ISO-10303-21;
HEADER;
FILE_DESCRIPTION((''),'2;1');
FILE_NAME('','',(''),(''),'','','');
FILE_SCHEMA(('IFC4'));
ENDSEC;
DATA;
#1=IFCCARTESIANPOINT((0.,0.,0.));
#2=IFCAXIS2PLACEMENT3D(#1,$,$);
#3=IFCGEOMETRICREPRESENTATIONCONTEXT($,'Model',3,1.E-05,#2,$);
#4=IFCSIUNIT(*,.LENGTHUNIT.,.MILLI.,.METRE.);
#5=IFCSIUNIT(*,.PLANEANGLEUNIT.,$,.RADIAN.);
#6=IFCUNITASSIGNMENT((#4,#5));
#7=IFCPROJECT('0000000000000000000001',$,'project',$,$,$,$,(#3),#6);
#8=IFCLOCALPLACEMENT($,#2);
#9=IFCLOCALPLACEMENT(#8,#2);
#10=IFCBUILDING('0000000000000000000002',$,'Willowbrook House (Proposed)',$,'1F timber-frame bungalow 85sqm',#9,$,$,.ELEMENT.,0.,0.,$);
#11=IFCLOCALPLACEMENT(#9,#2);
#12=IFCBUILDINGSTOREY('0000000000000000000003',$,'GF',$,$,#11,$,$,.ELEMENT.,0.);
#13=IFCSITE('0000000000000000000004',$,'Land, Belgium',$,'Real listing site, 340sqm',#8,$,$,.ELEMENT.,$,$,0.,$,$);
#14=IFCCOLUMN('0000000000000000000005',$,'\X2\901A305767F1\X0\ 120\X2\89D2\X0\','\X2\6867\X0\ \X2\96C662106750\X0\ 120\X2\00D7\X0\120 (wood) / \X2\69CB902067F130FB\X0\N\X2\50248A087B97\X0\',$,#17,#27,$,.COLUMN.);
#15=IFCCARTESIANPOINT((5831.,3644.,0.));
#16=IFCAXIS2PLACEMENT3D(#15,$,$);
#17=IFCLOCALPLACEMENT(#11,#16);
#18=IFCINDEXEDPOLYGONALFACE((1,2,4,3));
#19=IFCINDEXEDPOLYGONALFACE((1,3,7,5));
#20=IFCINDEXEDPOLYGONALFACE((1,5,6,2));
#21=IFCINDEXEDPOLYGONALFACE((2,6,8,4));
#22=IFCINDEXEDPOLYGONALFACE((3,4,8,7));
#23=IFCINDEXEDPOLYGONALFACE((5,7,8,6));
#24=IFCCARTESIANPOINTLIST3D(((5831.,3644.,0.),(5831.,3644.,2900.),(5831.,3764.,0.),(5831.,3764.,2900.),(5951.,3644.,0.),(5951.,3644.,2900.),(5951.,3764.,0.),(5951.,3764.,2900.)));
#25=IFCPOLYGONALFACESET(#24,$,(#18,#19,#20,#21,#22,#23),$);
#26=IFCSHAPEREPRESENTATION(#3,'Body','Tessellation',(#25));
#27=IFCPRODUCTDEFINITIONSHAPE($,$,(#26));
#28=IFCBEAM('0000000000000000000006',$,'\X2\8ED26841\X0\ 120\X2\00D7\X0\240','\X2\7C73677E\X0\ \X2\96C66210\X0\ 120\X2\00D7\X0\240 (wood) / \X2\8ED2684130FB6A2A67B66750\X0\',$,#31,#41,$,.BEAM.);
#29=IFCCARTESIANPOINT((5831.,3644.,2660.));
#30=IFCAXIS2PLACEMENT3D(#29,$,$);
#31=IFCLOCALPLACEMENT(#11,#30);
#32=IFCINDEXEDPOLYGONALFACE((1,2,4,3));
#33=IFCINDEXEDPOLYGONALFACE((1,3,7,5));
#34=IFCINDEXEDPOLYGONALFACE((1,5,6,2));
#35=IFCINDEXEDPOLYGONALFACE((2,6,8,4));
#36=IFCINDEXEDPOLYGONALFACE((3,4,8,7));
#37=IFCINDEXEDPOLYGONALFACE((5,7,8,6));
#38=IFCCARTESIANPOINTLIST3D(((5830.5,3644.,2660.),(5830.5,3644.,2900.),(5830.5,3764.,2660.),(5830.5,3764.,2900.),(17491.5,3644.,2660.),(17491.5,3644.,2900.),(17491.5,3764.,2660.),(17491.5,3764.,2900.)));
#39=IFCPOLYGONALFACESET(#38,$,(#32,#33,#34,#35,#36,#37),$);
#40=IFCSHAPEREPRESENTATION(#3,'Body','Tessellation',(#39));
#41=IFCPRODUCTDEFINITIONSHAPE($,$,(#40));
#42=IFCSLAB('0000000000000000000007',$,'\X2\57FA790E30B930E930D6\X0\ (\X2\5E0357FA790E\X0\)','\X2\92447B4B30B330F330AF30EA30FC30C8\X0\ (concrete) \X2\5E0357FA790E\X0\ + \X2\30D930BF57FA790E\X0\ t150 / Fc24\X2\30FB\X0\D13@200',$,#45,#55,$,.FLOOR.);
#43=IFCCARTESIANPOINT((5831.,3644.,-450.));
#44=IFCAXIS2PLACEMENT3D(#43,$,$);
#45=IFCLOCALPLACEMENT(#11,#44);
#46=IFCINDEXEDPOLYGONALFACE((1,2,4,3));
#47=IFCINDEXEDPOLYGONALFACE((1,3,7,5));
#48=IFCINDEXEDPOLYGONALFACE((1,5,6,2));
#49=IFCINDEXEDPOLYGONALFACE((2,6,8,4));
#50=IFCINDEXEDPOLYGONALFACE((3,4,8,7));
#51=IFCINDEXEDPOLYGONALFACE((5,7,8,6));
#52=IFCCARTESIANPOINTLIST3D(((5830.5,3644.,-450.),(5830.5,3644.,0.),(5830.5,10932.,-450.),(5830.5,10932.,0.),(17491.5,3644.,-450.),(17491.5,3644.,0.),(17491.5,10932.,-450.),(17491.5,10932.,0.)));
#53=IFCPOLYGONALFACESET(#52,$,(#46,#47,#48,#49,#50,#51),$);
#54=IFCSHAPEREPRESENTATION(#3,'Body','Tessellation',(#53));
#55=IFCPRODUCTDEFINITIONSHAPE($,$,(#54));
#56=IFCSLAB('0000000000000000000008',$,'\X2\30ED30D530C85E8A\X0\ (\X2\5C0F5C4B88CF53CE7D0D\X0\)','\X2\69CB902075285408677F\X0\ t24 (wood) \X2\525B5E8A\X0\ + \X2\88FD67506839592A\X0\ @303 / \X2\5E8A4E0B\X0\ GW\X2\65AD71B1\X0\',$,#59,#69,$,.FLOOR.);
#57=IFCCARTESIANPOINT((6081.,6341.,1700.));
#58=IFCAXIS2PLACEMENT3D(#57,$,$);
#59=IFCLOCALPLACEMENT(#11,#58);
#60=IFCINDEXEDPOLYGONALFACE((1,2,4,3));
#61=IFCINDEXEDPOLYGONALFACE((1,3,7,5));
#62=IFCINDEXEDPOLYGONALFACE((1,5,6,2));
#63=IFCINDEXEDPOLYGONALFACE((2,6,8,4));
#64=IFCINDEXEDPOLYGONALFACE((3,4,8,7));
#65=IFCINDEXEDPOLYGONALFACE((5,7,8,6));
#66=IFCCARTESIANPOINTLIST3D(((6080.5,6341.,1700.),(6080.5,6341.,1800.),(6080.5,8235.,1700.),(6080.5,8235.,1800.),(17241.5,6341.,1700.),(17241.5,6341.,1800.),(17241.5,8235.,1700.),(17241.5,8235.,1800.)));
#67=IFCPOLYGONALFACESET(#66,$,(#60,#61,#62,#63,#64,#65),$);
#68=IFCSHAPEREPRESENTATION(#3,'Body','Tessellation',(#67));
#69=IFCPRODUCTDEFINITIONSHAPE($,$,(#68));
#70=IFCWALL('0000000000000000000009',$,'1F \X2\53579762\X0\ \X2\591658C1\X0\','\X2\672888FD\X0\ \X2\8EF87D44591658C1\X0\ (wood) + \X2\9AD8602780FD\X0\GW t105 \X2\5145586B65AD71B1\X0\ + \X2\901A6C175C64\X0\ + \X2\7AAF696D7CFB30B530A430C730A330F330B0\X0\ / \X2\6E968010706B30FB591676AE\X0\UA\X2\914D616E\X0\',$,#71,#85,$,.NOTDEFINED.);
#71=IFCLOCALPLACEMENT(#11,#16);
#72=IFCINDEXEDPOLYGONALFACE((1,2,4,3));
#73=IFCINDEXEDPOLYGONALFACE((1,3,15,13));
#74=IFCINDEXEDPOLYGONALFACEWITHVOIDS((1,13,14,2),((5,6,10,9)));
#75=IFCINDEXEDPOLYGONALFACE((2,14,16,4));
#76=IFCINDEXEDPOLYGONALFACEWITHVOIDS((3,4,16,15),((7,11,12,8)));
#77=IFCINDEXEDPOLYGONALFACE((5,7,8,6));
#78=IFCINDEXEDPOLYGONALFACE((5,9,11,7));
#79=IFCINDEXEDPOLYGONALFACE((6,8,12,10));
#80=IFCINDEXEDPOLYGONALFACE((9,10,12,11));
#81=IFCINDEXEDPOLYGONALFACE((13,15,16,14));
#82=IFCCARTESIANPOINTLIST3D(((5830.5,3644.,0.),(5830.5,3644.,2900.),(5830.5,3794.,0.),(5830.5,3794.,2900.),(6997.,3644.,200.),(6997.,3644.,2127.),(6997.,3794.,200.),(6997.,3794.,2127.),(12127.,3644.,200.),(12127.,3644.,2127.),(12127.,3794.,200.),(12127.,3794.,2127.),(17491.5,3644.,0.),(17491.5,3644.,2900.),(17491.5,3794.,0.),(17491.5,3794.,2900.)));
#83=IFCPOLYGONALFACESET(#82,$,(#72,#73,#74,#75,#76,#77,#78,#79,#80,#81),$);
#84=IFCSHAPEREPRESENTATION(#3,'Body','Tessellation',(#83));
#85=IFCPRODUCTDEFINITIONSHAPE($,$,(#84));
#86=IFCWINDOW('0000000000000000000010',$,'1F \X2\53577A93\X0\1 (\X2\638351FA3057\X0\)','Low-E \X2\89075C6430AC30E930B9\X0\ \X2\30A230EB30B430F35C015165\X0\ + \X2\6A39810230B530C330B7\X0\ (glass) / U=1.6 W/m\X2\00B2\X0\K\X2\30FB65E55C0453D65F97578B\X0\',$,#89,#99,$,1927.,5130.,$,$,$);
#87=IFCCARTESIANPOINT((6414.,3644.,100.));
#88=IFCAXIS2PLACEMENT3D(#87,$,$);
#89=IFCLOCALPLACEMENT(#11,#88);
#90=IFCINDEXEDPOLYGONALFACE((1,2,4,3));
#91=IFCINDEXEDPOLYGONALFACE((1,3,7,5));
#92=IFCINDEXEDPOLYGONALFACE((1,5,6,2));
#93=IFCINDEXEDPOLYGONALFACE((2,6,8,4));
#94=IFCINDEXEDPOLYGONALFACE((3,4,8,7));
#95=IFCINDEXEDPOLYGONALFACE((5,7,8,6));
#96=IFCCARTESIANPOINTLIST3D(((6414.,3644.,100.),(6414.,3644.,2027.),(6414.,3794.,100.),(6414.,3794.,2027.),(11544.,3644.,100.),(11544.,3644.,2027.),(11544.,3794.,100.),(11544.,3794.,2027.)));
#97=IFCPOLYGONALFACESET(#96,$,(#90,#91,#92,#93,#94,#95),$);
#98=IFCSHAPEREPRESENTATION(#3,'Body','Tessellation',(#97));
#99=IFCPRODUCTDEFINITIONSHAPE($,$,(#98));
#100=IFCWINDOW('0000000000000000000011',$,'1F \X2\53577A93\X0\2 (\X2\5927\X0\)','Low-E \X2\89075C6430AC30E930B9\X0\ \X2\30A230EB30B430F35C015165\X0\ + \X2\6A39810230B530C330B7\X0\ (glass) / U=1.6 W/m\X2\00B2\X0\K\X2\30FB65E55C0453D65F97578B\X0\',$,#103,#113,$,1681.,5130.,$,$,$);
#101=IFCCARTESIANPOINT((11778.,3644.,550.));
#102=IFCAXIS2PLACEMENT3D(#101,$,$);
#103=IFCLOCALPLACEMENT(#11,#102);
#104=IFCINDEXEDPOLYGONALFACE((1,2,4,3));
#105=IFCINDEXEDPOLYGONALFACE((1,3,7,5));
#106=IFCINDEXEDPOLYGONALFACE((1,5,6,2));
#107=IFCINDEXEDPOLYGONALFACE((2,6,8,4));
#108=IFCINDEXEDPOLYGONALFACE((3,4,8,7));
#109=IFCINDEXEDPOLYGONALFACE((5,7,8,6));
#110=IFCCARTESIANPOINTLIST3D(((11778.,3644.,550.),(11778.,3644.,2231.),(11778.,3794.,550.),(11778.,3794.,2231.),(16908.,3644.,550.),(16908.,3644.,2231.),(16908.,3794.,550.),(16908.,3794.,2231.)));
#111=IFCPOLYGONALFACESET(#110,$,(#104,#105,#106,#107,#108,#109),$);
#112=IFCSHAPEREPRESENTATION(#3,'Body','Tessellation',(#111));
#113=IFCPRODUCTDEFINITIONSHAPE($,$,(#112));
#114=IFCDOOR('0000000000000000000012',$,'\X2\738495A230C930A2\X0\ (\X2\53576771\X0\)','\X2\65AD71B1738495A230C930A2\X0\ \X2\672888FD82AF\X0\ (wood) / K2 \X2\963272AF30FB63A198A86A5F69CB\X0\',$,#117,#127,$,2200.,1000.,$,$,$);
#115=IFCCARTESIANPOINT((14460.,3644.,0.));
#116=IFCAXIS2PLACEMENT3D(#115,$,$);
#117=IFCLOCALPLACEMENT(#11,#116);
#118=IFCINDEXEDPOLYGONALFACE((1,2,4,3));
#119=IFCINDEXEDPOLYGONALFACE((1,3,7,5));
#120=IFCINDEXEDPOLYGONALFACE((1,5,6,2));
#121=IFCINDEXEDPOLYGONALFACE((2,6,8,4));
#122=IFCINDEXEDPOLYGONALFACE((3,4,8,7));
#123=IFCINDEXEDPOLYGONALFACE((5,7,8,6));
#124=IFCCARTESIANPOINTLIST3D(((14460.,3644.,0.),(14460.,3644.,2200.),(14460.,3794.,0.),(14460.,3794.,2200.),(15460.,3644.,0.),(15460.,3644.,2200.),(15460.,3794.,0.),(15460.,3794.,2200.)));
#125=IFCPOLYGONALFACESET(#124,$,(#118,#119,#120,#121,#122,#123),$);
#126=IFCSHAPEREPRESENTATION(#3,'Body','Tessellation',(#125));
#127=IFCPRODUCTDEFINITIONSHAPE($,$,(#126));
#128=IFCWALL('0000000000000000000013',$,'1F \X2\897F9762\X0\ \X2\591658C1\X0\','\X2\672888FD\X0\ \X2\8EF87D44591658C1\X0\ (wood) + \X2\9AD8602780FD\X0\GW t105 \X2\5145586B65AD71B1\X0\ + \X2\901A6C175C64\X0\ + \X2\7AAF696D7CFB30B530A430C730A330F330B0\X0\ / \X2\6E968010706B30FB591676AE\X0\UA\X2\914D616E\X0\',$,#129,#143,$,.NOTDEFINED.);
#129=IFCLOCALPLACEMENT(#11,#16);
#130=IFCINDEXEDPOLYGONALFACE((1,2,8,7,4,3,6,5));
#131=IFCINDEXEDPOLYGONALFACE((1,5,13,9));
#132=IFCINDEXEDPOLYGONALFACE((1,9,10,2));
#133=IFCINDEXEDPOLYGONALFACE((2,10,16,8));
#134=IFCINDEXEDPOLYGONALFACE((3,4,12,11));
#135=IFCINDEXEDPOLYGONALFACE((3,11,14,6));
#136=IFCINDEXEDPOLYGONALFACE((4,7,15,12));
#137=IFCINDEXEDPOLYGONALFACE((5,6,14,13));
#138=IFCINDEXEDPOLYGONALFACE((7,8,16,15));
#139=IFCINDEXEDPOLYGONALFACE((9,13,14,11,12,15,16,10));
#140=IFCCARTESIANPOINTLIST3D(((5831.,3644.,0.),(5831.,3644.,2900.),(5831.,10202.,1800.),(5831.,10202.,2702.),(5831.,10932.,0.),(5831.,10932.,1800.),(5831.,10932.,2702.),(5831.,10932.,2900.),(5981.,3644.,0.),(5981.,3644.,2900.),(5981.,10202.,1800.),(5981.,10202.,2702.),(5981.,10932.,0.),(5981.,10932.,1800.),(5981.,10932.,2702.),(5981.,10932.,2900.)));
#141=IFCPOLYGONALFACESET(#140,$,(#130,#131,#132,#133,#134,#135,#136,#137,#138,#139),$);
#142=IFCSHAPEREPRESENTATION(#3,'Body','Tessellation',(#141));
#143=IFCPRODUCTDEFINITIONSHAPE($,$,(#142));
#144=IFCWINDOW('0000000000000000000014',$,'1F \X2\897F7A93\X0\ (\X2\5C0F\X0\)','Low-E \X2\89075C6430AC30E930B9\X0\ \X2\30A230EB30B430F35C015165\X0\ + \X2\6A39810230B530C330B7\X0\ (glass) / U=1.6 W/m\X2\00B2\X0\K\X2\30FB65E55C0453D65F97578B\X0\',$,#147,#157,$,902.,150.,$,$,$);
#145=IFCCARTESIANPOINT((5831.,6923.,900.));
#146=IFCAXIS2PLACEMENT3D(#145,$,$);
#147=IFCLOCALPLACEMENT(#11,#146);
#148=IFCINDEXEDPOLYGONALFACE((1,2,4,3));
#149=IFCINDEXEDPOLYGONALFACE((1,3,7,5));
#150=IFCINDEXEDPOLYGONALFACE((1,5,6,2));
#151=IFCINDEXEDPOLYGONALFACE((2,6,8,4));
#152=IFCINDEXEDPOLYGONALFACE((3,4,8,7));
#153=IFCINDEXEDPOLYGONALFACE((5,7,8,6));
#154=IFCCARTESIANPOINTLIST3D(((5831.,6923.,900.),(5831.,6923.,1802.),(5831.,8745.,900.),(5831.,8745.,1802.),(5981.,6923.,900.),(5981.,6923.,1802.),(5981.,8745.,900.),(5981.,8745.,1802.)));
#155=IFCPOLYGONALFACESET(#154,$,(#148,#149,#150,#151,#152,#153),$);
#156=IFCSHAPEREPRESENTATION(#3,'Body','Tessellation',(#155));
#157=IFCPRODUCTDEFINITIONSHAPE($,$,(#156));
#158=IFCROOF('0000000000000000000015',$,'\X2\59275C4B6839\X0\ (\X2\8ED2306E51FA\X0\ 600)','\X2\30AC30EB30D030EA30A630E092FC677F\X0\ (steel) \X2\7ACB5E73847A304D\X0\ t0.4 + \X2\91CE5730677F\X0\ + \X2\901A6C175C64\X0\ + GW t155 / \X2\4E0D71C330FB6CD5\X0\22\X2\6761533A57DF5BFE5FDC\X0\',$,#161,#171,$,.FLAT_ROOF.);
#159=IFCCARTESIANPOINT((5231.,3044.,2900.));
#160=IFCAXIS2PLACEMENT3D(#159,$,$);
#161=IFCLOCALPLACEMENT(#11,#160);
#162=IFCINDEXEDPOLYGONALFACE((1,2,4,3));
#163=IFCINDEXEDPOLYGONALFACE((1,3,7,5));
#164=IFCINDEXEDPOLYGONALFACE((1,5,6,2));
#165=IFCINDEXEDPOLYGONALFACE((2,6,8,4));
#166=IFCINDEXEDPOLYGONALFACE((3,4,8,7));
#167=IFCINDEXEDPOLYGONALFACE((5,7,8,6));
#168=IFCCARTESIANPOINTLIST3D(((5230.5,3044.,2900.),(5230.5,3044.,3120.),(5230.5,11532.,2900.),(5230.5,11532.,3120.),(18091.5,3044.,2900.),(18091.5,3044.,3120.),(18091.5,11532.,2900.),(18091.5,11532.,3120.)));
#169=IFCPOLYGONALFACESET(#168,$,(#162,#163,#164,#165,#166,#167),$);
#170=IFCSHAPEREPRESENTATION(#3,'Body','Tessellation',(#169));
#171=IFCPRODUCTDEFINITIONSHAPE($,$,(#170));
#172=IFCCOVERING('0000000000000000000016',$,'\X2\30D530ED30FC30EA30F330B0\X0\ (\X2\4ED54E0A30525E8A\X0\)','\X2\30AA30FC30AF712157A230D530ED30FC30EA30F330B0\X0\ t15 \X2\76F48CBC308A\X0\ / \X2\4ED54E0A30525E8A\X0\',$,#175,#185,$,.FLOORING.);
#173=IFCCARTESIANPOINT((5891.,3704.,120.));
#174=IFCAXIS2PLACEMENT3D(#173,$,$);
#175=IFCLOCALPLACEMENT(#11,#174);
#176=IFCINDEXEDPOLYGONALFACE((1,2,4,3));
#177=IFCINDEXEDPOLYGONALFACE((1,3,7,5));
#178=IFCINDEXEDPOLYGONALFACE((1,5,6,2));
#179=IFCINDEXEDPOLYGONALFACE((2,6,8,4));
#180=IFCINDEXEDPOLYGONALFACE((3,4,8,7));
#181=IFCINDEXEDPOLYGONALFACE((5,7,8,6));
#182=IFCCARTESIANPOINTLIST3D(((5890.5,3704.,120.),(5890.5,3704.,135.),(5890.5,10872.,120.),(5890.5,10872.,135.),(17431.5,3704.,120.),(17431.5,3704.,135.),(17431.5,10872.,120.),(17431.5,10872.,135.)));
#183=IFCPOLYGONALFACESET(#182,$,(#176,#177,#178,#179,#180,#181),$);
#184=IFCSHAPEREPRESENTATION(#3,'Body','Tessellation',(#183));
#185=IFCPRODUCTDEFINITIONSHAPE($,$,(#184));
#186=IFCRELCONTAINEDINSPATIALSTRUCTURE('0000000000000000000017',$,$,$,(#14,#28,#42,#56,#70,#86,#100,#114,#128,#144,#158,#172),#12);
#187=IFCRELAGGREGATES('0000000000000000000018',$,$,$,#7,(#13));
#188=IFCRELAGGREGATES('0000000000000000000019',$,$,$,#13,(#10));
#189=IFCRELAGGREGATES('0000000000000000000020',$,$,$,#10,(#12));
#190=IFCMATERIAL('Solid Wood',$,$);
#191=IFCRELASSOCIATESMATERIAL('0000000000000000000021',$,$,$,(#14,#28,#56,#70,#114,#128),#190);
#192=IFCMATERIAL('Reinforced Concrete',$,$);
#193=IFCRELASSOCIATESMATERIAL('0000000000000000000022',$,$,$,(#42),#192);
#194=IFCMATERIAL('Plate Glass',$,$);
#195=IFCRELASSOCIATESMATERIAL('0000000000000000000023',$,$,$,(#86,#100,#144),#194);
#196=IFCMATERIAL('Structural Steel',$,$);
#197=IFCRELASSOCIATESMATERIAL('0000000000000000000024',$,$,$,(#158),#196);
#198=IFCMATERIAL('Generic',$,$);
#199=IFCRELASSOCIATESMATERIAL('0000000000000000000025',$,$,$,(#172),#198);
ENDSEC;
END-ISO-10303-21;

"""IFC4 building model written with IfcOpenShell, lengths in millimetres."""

from ifc_helpers import new_model, si_unit, frame, frame_2d, origin, place, context, project, spatial, rectangle, extrude, material, element, fill, save


model = new_model("IFC4")

# Units and contexts
model_context = context("Model", 3, precision=1e-05, world=origin())
ifc_project = project(units=[si_unit("LENGTHUNIT", "METRE", prefix="MILLI"), si_unit("PLANEANGLEUNIT", "RADIAN")], contexts=[model_context])

# Site, building, storey
site_placement = place(None, origin())
site = spatial("IfcSite", under=ifc_project, at=site_placement, Name="Land, Belgium", ObjectType="Real listing site, 340sqm", CompositionType="ELEMENT", RefElevation=0.0)
building_placement = place(site_placement, origin())
building = spatial("IfcBuilding", under=site, at=building_placement, Name="Willowbrook House (Proposed)", ObjectType="1F timber-frame bungalow 85sqm", CompositionType="ELEMENT", ElevationOfRefHeight=0.0, ElevationOfTerrain=0.0)
storey_placement = place(building_placement, origin())
storey = spatial("IfcBuildingStorey", under=building, at=storey_placement, Name="GF", CompositionType="ELEMENT", Elevation=0.0)

# Column
ifc_material_1 = material(Name="Solid Wood")
column_1_placement = place(storey_placement, frame((5831.0, 3644.0, 0.0)))
element("IfcColumn", 1, at=column_1_placement, inside=storey, material=ifc_material_1, Name="通し柱 120角", Description="桧 集成材 120×120 (wood) / 構造柱・N値計算", PredefinedType="COLUMN", context=model_context, shape_type="SweptSolid", body=[
    extrude(rectangle(XDim=120.0, YDim=120.0, at=frame_2d((60.0, 60.0))), frame((5831.0, 3644.0, 0.0)), (0.0, 0.0, 1.0), 2900.0),
])

# Beam
beam_1_placement = place(storey_placement, frame((5831.0, 3644.0, 2660.0)))
element("IfcBeam", 2, at=beam_1_placement, inside=storey, material=ifc_material_1, Name="軒桁 120×240", Description="米松 集成 120×240 (wood) / 軒桁・横架材", PredefinedType="BEAM", context=model_context, shape_type="SweptSolid", body=[
    extrude(rectangle(XDim=11661.0, YDim=120.0, at=frame_2d((5830.0, 60.0))), frame((5831.0, 3644.0, 2660.0)), (0.0, 0.0, 1.0), 240.0),
])

# Slabs
ifc_material_2 = material(Name="Reinforced Concrete")
slab_1_placement = place(storey_placement, frame((5831.0, 3644.0, -450.0)))
element("IfcSlab", 3, at=slab_1_placement, inside=storey, material=ifc_material_2, Name="基礎スラブ (布基礎)", Description="鉄筋コンクリート (concrete) 布基礎 + ベタ基礎 t150 / Fc24・D13@200", PredefinedType="FLOOR", context=model_context, shape_type="SweptSolid", body=[
    extrude(rectangle(XDim=11661.0, YDim=7288.0, at=frame_2d((5830.0, 3644.0))), frame((5831.0, 3644.0, -450.0)), (0.0, 0.0, 1.0), 450.0),
])
slab_2_placement = place(storey_placement, frame((6081.0, 6341.0, 1700.0)))
element("IfcSlab", 4, at=slab_2_placement, inside=storey, material=ifc_material_1, Name="ロフト床 (小屋裏収納)", Description="構造用合板 t24 (wood) 剛床 + 製材根太 @303 / 床下 GW断熱", PredefinedType="FLOOR", context=model_context, shape_type="SweptSolid", body=[
    extrude(rectangle(XDim=11161.0, YDim=1894.0, at=frame_2d((5580.0, 947.0))), frame((6081.0, 6341.0, 1700.0)), (0.0, 0.0, 1.0), 100.0),
])

# Wall, openings, windows, door
wall_1_placement = place(storey_placement, frame((5831.0, 3644.0, 0.0)))
wall_1 = element("IfcWall", 5, at=wall_1_placement, inside=storey, material=ifc_material_1, Name="1F 南面 外壁", Description="木製 軸組外壁 (wood) + 高性能GW t105 充填断熱 + 通気層 + 窯業系サイディング / 準耐火・外皮UA配慮", PredefinedType="NOTDEFINED", context=model_context, shape_type="SweptSolid", body=[
    extrude(rectangle(XDim=11661.0, YDim=150.0, at=frame_2d((5830.0, 75.0))), frame((5831.0, 3644.0, 0.0)), (0.0, 0.0, 1.0), 2900.0),
])
opening_1_placement = place(storey_placement, frame((6414.0, 3644.0, 100.0)))
opening_1 = element("IfcOpeningElement", 6, at=opening_1_placement, cuts=wall_1, PredefinedType="NOTDEFINED", context=model_context, shape_type="SweptSolid", body=[
    extrude(rectangle(XDim=5130.0, YDim=150.0, at=frame_2d((2565.0, 75.0))), frame((6414.0, 3644.0, 100.0)), (0.0, 0.0, 1.0), 1927.0),
])
opening_2_placement = place(storey_placement, frame((11778.0, 3644.0, 550.0)))
opening_2 = element("IfcOpeningElement", 7, at=opening_2_placement, cuts=wall_1, PredefinedType="NOTDEFINED", context=model_context, shape_type="SweptSolid", body=[
    extrude(rectangle(XDim=5130.0, YDim=150.0, at=frame_2d((2565.0, 75.0))), frame((11778.0, 3644.0, 550.0)), (0.0, 0.0, 1.0), 1681.0),
])
opening_3_placement = place(storey_placement, frame((14460.0, 3644.0, 0.0)))
opening_3 = element("IfcOpeningElement", 8, at=opening_3_placement, cuts=wall_1, PredefinedType="NOTDEFINED", context=model_context, shape_type="SweptSolid", body=[
    extrude(rectangle(XDim=1000.0, YDim=150.0, at=frame_2d((500.0, 75.0))), frame((14460.0, 3644.0, 0.0)), (0.0, 0.0, 1.0), 2200.0),
])
ifc_material_3 = material(Name="Plate Glass")
window_1_placement = place(storey_placement, frame((6414.0, 3644.0, 100.0)))
window_1 = element("IfcWindow", 9, at=window_1_placement, inside=storey, material=ifc_material_3, Name="1F 南窓1 (掃出し)", Description="Low-E 複層ガラス アルゴン封入 + 樹脂サッシ (glass) / U=1.6 W/m²K・日射取得型", OverallHeight=1927.0, OverallWidth=5130.0, context=model_context, shape_type="SweptSolid", body=[
    extrude(rectangle(XDim=5130.0, YDim=150.0, at=frame_2d((2565.0, 75.0))), frame((6414.0, 3644.0, 100.0)), (0.0, 0.0, 1.0), 1927.0),
])
fill(opening_1, window_1)
window_2_placement = place(storey_placement, frame((11778.0, 3644.0, 550.0)))
window_2 = element("IfcWindow", 10, at=window_2_placement, inside=storey, material=ifc_material_3, Name="1F 南窓2 (大)", Description="Low-E 複層ガラス アルゴン封入 + 樹脂サッシ (glass) / U=1.6 W/m²K・日射取得型", OverallHeight=1681.0, OverallWidth=5130.0, context=model_context, shape_type="SweptSolid", body=[
    extrude(rectangle(XDim=5130.0, YDim=150.0, at=frame_2d((2565.0, 75.0))), frame((11778.0, 3644.0, 550.0)), (0.0, 0.0, 1.0), 1681.0),
])
fill(opening_2, window_2)
door_placement = place(storey_placement, frame((14460.0, 3644.0, 0.0)))
door = element("IfcDoor", 11, at=door_placement, inside=storey, material=ifc_material_1, Name="玄関ドア (南東)", Description="断熱玄関ドア 木製芯 (wood) / K2 防犯・採風機構", OverallHeight=2200.0, OverallWidth=1000.0, context=model_context, shape_type="SweptSolid", body=[
    extrude(rectangle(XDim=1000.0, YDim=150.0, at=frame_2d((500.0, 75.0))), frame((14460.0, 3644.0, 0.0)), (0.0, 0.0, 1.0), 2200.0),
])
fill(opening_3, door)

# Wall, opening, window
wall_2_placement = place(storey_placement, frame((5831.0, 3644.0, 0.0)))
wall_2 = element("IfcWall", 12, at=wall_2_placement, inside=storey, material=ifc_material_1, Name="1F 西面 外壁", Description="木製 軸組外壁 (wood) + 高性能GW t105 充填断熱 + 通気層 + 窯業系サイディング / 準耐火・外皮UA配慮", PredefinedType="NOTDEFINED", context=model_context, shape_type="SweptSolid", body=[
    extrude(rectangle(XDim=150.0, YDim=7288.0, at=frame_2d((75.0, 3644.0))), frame((5831.0, 3644.0, 0.0)), (0.0, 0.0, 1.0), 2900.0),
])
opening_4_placement = place(storey_placement, frame((5831.0, 6923.0, 900.0)))
opening_4 = element("IfcOpeningElement", 13, at=opening_4_placement, cuts=wall_2, PredefinedType="NOTDEFINED", context=model_context, shape_type="SweptSolid", body=[
    extrude(rectangle(XDim=150.0, YDim=1822.0, at=frame_2d((75.0, 911.0))), frame((5831.0, 6923.0, 900.0)), (0.0, 0.0, 1.0), 902.0),
])
window_3_placement = place(storey_placement, frame((5831.0, 6923.0, 900.0)))
window_3 = element("IfcWindow", 14, at=window_3_placement, inside=storey, material=ifc_material_3, Name="1F 西窓 (小)", Description="Low-E 複層ガラス アルゴン封入 + 樹脂サッシ (glass) / U=1.6 W/m²K・日射取得型", OverallHeight=902.0, OverallWidth=150.0, context=model_context, shape_type="SweptSolid", body=[
    extrude(rectangle(XDim=150.0, YDim=1822.0, at=frame_2d((75.0, 911.0))), frame((5831.0, 6923.0, 900.0)), (0.0, 0.0, 1.0), 902.0),
])
fill(opening_4, window_3)

# Roof
ifc_material_4 = material(Name="Structural Steel")
roof_placement = place(storey_placement, frame((5231.0, 3044.0, 2900.0)))
element("IfcRoof", 15, at=roof_placement, inside=storey, material=ifc_material_4, Name="大屋根 (軒の出 600)", Description="ガルバリウム鋼板 (steel) 立平葺き t0.4 + 野地板 + 通気層 + GW t155 / 不燃・法22条区域対応", PredefinedType="FLAT_ROOF", context=model_context, shape_type="SweptSolid", body=[
    extrude(rectangle(XDim=12861.0, YDim=8488.0, at=frame_2d((6430.0, 4244.0))), frame((5231.0, 3044.0, 2900.0)), (0.0, 0.0, 1.0), 220.0),
])

# Covering
ifc_material_5 = material(Name="Generic")
covering_1_placement = place(storey_placement, frame((5891.0, 3704.0, 120.0)))
element("IfcCovering", 16, at=covering_1_placement, inside=storey, material=ifc_material_5, Name="フローリング (仕上げ床)", Description="オーク無垢フローリング t15 直貼り / 仕上げ床", PredefinedType="FLOORING", context=model_context, shape_type="SweptSolid", body=[
    extrude(rectangle(XDim=11541.0, YDim=7168.0, at=frame_2d((5770.0, 3584.0))), frame((5891.0, 3704.0, 120.0)), (0.0, 0.0, 1.0), 15.0),
])

save(model, "model.ifc")
